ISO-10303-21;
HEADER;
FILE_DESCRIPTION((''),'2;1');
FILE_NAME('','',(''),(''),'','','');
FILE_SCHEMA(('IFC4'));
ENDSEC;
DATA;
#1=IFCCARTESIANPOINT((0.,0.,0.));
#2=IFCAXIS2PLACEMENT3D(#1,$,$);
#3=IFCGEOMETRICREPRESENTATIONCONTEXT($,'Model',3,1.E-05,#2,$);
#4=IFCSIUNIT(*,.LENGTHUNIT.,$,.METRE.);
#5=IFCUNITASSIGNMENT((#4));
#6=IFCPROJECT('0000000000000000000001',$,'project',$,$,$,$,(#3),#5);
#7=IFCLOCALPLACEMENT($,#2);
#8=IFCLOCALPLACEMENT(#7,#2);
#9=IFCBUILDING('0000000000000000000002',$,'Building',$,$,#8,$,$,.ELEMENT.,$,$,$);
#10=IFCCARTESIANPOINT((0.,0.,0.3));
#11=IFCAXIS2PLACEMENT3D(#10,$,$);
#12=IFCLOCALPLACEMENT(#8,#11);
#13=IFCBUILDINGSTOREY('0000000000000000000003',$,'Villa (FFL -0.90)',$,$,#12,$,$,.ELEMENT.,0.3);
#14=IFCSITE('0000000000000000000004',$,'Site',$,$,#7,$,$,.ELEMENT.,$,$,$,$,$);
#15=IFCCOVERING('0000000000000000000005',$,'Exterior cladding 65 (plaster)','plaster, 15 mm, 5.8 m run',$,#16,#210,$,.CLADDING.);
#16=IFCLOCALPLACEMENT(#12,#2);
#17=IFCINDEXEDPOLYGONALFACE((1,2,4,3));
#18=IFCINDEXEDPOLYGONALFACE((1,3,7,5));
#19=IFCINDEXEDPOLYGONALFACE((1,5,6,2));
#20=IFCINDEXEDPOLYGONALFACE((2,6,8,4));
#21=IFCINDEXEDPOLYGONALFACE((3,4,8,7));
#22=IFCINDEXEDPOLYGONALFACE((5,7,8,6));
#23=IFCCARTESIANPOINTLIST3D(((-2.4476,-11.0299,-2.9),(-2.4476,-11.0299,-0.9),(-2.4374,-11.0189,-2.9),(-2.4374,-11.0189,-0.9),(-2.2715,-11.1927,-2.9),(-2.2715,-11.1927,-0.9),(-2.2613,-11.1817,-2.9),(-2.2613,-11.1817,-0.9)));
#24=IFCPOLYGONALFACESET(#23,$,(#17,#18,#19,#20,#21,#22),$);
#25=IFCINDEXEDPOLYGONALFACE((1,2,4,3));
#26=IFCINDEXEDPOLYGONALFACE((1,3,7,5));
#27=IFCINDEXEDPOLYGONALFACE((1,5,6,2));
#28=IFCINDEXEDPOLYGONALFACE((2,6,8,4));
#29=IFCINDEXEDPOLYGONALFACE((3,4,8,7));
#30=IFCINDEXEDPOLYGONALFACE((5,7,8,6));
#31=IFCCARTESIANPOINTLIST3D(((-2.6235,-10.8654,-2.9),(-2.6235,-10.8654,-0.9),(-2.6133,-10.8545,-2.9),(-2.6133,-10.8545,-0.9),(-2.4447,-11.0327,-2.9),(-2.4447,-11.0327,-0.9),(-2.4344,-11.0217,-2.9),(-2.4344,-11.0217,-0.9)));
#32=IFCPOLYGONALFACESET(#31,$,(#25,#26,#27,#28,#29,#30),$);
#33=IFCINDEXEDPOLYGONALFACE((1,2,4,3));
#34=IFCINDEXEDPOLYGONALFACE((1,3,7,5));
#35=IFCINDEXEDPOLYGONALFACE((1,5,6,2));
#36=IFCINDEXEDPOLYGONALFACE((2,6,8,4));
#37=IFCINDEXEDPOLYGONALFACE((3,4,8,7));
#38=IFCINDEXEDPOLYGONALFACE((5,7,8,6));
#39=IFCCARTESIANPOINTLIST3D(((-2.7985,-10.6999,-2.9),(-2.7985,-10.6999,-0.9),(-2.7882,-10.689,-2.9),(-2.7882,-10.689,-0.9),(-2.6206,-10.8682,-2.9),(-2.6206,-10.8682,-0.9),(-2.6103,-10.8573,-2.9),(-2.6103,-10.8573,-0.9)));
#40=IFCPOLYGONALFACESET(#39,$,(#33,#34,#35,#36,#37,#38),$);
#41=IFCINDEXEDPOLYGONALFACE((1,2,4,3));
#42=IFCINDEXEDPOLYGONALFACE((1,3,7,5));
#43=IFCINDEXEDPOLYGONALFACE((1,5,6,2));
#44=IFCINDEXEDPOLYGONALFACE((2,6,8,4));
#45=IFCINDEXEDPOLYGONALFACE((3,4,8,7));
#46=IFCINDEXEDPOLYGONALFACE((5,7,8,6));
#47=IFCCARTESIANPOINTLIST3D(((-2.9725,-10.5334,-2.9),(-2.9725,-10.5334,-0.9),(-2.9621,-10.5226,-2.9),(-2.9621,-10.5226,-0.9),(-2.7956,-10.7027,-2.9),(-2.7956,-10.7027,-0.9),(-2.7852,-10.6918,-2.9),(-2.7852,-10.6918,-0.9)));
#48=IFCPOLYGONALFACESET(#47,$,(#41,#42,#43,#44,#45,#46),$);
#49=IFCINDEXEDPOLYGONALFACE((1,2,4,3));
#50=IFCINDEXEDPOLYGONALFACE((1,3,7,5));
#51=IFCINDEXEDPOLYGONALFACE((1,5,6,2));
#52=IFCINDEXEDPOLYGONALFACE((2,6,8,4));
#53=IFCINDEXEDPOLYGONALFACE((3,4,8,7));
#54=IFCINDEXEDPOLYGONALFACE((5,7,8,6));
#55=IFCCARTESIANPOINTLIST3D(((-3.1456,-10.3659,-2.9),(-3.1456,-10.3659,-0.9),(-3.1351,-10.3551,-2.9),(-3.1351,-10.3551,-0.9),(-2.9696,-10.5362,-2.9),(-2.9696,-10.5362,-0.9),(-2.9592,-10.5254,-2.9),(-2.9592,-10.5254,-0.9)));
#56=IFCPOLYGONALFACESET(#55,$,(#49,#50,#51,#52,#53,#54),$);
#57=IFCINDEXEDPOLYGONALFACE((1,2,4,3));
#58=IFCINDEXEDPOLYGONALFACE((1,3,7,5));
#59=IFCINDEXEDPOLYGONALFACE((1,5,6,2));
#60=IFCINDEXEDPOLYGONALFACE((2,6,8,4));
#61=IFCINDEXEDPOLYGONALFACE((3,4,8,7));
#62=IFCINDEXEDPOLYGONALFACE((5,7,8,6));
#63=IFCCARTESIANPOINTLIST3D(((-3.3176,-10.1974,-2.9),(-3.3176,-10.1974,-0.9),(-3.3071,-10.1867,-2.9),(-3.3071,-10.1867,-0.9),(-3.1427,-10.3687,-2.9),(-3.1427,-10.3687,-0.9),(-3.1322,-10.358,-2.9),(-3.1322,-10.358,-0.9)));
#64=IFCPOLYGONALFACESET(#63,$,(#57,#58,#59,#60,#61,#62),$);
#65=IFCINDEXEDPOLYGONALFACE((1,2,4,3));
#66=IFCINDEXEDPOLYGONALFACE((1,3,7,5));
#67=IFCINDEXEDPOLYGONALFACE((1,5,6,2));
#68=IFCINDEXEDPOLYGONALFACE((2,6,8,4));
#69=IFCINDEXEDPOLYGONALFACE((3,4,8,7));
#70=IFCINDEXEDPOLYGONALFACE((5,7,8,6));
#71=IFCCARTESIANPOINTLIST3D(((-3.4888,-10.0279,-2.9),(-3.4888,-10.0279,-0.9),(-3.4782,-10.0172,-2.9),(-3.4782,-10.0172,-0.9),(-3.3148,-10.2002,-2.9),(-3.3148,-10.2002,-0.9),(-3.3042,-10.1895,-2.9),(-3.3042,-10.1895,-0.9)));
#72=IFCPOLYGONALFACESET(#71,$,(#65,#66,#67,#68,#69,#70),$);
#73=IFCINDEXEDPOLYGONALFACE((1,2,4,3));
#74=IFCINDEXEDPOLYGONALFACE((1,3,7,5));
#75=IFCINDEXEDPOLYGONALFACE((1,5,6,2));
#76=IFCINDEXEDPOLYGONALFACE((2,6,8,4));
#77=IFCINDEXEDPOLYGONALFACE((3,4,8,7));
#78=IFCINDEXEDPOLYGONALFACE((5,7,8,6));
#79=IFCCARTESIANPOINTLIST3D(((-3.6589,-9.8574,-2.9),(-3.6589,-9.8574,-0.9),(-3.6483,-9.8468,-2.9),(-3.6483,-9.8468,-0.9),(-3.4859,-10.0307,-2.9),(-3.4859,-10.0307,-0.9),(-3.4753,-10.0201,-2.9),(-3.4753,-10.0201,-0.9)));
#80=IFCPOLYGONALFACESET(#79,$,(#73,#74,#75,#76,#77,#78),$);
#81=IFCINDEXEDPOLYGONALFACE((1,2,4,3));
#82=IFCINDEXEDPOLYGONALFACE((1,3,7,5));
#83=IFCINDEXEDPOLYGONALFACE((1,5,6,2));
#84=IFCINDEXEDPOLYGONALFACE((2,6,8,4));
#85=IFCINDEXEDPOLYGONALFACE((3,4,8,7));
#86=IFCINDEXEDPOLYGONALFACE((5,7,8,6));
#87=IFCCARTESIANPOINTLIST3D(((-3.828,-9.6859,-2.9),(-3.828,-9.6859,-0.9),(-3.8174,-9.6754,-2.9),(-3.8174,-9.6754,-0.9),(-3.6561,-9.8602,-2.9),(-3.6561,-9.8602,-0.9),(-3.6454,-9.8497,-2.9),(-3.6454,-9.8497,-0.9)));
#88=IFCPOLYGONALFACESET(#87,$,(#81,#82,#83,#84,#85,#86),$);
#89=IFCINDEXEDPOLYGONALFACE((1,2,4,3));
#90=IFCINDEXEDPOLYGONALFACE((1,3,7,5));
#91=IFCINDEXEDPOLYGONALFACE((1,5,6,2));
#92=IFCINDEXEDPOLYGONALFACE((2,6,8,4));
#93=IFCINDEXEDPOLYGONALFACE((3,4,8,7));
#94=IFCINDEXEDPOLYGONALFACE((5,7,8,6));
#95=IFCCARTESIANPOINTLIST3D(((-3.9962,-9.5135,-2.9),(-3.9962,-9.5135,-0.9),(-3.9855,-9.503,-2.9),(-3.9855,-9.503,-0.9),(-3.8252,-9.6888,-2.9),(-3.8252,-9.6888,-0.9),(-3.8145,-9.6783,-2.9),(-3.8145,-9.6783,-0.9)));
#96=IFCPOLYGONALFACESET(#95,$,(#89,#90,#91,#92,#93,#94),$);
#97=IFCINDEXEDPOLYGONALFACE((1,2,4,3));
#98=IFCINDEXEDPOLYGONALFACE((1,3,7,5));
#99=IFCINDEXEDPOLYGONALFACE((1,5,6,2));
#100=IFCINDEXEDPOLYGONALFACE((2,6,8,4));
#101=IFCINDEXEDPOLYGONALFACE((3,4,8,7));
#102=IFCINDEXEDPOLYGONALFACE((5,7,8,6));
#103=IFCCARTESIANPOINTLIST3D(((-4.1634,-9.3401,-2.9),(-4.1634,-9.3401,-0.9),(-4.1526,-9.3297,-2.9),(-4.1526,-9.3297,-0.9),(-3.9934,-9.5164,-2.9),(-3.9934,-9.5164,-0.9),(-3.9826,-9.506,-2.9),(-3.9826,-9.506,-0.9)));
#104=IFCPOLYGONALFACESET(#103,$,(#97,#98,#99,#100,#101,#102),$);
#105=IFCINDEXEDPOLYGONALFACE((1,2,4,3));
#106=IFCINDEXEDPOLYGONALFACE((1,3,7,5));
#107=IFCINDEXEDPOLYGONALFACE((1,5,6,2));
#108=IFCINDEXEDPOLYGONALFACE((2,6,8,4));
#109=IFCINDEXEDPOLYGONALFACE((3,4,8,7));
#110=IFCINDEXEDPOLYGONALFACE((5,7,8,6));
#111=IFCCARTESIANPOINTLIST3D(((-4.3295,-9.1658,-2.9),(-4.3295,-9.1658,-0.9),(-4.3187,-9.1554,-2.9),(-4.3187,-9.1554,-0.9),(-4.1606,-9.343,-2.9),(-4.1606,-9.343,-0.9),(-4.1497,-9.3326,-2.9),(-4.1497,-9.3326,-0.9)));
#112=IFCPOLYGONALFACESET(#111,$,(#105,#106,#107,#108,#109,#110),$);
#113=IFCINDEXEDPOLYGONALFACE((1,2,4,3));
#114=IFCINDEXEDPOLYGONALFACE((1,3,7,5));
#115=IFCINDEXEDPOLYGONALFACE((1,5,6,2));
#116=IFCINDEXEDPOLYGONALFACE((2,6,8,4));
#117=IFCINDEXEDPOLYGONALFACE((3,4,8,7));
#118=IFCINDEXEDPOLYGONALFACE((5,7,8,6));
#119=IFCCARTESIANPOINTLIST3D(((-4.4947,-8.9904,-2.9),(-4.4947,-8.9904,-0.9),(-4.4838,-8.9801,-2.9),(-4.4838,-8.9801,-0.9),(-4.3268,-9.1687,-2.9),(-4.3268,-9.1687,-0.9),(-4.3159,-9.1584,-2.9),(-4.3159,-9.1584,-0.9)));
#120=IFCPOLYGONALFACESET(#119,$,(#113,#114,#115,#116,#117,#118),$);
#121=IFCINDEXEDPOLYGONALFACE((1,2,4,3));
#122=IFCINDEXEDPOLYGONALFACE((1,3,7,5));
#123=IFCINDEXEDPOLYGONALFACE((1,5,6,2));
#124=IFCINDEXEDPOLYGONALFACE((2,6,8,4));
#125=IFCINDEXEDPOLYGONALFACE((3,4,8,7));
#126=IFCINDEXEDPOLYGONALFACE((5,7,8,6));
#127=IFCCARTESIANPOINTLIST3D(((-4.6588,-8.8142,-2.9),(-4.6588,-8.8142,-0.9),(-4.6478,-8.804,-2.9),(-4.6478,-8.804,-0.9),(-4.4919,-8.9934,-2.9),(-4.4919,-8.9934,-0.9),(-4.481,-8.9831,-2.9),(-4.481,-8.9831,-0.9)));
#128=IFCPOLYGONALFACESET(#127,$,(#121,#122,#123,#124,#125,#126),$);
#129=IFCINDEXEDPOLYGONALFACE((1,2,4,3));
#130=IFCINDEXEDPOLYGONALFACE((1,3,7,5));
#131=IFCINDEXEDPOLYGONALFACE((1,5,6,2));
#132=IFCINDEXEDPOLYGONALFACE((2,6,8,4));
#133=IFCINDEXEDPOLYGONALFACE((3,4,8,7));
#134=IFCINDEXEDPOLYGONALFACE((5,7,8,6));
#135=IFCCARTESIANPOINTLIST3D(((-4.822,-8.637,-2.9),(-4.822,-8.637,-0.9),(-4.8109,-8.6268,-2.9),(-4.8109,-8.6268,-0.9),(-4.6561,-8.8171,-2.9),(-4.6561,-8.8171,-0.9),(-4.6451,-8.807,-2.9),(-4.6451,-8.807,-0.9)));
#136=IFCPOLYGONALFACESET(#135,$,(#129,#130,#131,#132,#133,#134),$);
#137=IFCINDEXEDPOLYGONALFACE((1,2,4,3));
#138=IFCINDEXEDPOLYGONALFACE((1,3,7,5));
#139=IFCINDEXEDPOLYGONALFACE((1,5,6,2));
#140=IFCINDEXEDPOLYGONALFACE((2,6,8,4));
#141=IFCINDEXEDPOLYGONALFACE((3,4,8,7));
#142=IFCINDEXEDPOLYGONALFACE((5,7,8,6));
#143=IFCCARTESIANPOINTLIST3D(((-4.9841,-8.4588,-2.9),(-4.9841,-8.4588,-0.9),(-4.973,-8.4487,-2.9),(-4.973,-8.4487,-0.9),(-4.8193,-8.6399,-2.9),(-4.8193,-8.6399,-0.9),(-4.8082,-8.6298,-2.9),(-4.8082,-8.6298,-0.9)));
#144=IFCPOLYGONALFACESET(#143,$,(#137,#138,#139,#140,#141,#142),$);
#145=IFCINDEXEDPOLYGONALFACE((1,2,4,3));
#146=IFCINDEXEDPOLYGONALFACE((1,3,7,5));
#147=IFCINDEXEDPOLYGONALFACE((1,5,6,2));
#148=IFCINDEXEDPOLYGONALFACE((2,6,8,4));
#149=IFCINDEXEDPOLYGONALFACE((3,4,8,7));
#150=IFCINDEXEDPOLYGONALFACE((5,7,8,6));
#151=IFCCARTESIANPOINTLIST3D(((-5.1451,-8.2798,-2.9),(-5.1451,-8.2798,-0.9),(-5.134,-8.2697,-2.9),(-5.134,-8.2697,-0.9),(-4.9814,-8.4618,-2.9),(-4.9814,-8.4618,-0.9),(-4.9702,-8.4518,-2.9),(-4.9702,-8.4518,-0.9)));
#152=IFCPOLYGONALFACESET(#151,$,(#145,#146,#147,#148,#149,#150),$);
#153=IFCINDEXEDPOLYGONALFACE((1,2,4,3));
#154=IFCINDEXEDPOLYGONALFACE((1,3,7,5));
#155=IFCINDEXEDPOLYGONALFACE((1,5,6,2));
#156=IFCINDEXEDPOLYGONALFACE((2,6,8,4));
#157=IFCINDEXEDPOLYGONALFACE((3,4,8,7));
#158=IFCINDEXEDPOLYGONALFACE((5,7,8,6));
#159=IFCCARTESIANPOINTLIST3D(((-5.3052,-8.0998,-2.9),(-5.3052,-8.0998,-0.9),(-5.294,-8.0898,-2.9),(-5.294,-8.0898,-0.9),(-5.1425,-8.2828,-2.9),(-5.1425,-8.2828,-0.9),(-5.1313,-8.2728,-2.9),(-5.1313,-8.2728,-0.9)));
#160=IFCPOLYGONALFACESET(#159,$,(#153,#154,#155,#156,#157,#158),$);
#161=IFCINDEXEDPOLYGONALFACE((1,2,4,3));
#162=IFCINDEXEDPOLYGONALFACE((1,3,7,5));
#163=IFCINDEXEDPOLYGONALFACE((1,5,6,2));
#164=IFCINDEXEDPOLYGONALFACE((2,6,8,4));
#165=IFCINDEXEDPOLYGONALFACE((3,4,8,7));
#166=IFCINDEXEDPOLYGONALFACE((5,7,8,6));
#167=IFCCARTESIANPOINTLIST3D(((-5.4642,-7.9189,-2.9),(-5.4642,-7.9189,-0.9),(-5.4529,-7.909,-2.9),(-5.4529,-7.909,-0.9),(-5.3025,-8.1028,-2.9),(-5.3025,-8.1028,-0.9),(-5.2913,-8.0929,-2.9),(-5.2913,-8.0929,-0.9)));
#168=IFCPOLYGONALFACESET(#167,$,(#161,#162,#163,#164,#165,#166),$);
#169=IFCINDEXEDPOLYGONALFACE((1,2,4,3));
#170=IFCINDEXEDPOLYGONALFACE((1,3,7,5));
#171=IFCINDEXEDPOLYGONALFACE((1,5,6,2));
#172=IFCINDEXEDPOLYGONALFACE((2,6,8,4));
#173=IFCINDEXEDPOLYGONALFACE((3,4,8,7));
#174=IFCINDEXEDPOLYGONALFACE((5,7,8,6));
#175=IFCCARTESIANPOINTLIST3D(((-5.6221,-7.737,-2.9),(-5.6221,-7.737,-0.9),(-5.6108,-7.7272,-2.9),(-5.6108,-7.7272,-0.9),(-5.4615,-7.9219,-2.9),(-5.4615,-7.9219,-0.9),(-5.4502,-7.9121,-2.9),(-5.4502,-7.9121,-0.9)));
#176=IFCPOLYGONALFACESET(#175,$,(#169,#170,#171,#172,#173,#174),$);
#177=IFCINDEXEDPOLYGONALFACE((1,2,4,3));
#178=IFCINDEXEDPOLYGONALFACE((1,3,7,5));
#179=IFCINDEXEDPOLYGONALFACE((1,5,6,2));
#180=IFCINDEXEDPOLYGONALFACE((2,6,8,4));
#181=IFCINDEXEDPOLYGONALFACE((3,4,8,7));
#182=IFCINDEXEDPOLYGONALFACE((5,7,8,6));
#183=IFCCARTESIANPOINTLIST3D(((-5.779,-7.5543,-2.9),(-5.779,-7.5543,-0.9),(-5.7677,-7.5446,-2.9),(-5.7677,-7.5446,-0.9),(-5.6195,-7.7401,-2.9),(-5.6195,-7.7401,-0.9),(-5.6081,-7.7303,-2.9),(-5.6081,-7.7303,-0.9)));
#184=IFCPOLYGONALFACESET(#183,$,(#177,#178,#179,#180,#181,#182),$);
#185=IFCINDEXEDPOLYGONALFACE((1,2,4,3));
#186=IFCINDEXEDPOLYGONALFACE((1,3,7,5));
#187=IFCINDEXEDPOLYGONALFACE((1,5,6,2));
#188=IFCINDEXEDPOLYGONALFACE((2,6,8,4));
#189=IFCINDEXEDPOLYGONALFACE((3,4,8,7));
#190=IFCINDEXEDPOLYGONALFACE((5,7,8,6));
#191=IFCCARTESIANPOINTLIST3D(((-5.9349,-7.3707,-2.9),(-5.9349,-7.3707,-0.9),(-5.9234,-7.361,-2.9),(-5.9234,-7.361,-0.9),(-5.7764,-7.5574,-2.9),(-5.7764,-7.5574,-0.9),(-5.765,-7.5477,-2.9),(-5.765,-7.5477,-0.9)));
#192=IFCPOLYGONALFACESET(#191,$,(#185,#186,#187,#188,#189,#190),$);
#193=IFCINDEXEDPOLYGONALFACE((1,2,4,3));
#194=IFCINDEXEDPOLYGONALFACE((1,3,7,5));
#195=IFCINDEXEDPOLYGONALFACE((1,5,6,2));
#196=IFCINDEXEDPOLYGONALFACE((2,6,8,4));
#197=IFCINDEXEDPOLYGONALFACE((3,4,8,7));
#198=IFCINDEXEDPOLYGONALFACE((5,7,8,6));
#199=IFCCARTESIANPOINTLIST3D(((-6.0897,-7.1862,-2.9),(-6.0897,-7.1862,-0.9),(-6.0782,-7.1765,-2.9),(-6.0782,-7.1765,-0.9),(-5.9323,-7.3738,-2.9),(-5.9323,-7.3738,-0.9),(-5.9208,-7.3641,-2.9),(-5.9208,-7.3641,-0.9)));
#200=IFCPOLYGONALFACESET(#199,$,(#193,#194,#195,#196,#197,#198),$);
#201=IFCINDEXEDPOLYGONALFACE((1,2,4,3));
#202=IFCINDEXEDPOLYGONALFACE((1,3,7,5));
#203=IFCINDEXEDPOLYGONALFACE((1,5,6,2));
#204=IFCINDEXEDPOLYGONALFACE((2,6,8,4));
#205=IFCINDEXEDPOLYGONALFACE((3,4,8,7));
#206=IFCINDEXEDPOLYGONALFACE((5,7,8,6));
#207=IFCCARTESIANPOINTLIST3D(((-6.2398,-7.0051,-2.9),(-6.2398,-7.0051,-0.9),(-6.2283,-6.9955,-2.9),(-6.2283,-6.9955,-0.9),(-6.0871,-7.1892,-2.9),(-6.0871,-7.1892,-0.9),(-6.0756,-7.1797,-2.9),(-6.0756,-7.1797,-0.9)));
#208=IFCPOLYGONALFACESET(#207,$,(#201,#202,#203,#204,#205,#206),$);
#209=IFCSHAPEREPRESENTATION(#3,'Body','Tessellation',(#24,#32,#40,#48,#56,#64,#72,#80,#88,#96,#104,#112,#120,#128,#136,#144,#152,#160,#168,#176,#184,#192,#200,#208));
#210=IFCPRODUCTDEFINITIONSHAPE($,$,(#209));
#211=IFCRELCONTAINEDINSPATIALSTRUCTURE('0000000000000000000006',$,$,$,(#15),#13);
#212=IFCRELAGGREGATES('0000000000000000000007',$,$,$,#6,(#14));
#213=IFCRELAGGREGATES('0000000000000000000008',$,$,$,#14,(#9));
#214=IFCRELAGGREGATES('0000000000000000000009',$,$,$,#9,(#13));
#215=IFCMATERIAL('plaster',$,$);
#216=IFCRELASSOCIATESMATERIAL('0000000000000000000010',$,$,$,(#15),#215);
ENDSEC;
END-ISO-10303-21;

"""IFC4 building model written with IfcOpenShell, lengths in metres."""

from ifc_helpers import new_model, si_unit, frame, origin, origin_with_axes, place, context, project, spatial, polyline, outline, extrude, material, element, save


model = new_model("IFC4")

# Units and contexts
model_context = context("Model", 3, precision=1e-05, world=origin())
ifc_project = project(units=[si_unit("LENGTHUNIT", "METRE")], contexts=[model_context])

# Site, building, storey
site_placement = place(None, origin())
site = spatial("IfcSite", under=ifc_project, at=site_placement, Name="Site", CompositionType="ELEMENT")
building_placement = place(site_placement, origin())
building = spatial("IfcBuilding", under=site, at=building_placement, Name="Building", CompositionType="ELEMENT")
storey_placement = place(building_placement, frame((0.0, 0.0, 0.3)))
storey = spatial("IfcBuildingStorey", under=building, at=storey_placement, Name="Villa (FFL -0.90)", CompositionType="ELEMENT", Elevation=0.3)

# Covering
ifc_material = material(Name="plaster")
covering_1_placement = place(storey_placement, origin_with_axes())
element("IfcCovering", 1, at=covering_1_placement, inside=storey, material=ifc_material, Name="Exterior cladding 65 (plaster)", Description="plaster, 15 mm, 5.8 m run", PredefinedType="CLADDING", context=model_context, shape_type="SweptSolid", body=[
    extrude(outline(polyline([(-2.2613, -11.1817), (-2.4374, -11.0189), (-2.4476, -11.0299), (-2.2715, -11.1927), (-2.2613, -11.1817)])), frame((0.0, 0.0, -2.9)), (0.0, 0.0, 1.0), 2.0),
    extrude(outline(polyline([(-2.4344, -11.0217), (-2.6133, -10.8545), (-2.6235, -10.8654), (-2.4447, -11.0327), (-2.4344, -11.0217)])), frame((0.0, 0.0, -2.9)), (0.0, 0.0, 1.0), 2.0),
    extrude(outline(polyline([(-2.6103, -10.8573), (-2.7882, -10.689), (-2.7985, -10.6999), (-2.6206, -10.8682), (-2.6103, -10.8573)])), frame((0.0, 0.0, -2.9)), (0.0, 0.0, 1.0), 2.0),
    extrude(outline(polyline([(-2.7852, -10.6918), (-2.9621, -10.5226), (-2.9725, -10.5334), (-2.7956, -10.7027), (-2.7852, -10.6918)])), frame((0.0, 0.0, -2.9)), (0.0, 0.0, 1.0), 2.0),
    extrude(outline(polyline([(-2.9592, -10.5254), (-3.1351, -10.3551), (-3.1456, -10.3659), (-2.9696, -10.5362), (-2.9592, -10.5254)])), frame((0.0, 0.0, -2.9)), (0.0, 0.0, 1.0), 2.0),
    extrude(outline(polyline([(-3.1322, -10.358), (-3.3071, -10.1867), (-3.3176, -10.1974), (-3.1427, -10.3687), (-3.1322, -10.358)])), frame((0.0, 0.0, -2.9)), (0.0, 0.0, 1.0), 2.0),
    extrude(outline(polyline([(-3.3042, -10.1895), (-3.4782, -10.0172), (-3.4888, -10.0279), (-3.3148, -10.2002), (-3.3042, -10.1895)])), frame((0.0, 0.0, -2.9)), (0.0, 0.0, 1.0), 2.0),
    extrude(outline(polyline([(-3.4753, -10.0201), (-3.6483, -9.8468), (-3.6589, -9.8574), (-3.4859, -10.0307), (-3.4753, -10.0201)])), frame((0.0, 0.0, -2.9)), (0.0, 0.0, 1.0), 2.0),
    extrude(outline(polyline([(-3.6454, -9.8497), (-3.8174, -9.6754), (-3.828, -9.6859), (-3.6561, -9.8602), (-3.6454, -9.8497)])), frame((0.0, 0.0, -2.9)), (0.0, 0.0, 1.0), 2.0),
    extrude(outline(polyline([(-3.8145, -9.6783), (-3.9855, -9.503), (-3.9962, -9.5135), (-3.8252, -9.6888), (-3.8145, -9.6783)])), frame((0.0, 0.0, -2.9)), (0.0, 0.0, 1.0), 2.0),
    extrude(outline(polyline([(-3.9826, -9.506), (-4.1526, -9.3297), (-4.1634, -9.3401), (-3.9934, -9.5164), (-3.9826, -9.506)])), frame((0.0, 0.0, -2.9)), (0.0, 0.0, 1.0), 2.0),
    extrude(outline(polyline([(-4.1497, -9.3326), (-4.3187, -9.1554), (-4.3295, -9.1658), (-4.1606, -9.343), (-4.1497, -9.3326)])), frame((0.0, 0.0, -2.9)), (0.0, 0.0, 1.0), 2.0),
    extrude(outline(polyline([(-4.3159, -9.1584), (-4.4838, -8.9801), (-4.4947, -8.9904), (-4.3268, -9.1687), (-4.3159, -9.1584)])), frame((0.0, 0.0, -2.9)), (0.0, 0.0, 1.0), 2.0),
    extrude(outline(polyline([(-4.481, -8.9831), (-4.6478, -8.804), (-4.6588, -8.8142), (-4.4919, -8.9934), (-4.481, -8.9831)])), frame((0.0, 0.0, -2.9)), (0.0, 0.0, 1.0), 2.0),
    extrude(outline(polyline([(-4.6451, -8.807), (-4.8109, -8.6268), (-4.822, -8.637), (-4.6561, -8.8171), (-4.6451, -8.807)])), frame((0.0, 0.0, -2.9)), (0.0, 0.0, 1.0), 2.0),
    extrude(outline(polyline([(-4.8082, -8.6298), (-4.973, -8.4487), (-4.9841, -8.4588), (-4.8193, -8.6399), (-4.8082, -8.6298)])), frame((0.0, 0.0, -2.9)), (0.0, 0.0, 1.0), 2.0),
    extrude(outline(polyline([(-4.9702, -8.4518), (-5.134, -8.2697), (-5.1451, -8.2798), (-4.9814, -8.4618), (-4.9702, -8.4518)])), frame((0.0, 0.0, -2.9)), (0.0, 0.0, 1.0), 2.0),
    extrude(outline(polyline([(-5.1313, -8.2728), (-5.294, -8.0898), (-5.3052, -8.0998), (-5.1425, -8.2828), (-5.1313, -8.2728)])), frame((0.0, 0.0, -2.9)), (0.0, 0.0, 1.0), 2.0),
    extrude(outline(polyline([(-5.2913, -8.0929), (-5.4529, -7.909), (-5.4642, -7.9189), (-5.3025, -8.1028), (-5.2913, -8.0929)])), frame((0.0, 0.0, -2.9)), (0.0, 0.0, 1.0), 2.0),
    extrude(outline(polyline([(-5.4502, -7.9121), (-5.6108, -7.7272), (-5.6221, -7.737), (-5.4615, -7.9219), (-5.4502, -7.9121)])), frame((0.0, 0.0, -2.9)), (0.0, 0.0, 1.0), 2.0),
    extrude(outline(polyline([(-5.6081, -7.7303), (-5.7677, -7.5446), (-5.779, -7.5543), (-5.6195, -7.7401), (-5.6081, -7.7303)])), frame((0.0, 0.0, -2.9)), (0.0, 0.0, 1.0), 2.0),
    extrude(outline(polyline([(-5.765, -7.5477), (-5.9234, -7.361), (-5.9349, -7.3707), (-5.7764, -7.5574), (-5.765, -7.5477)])), frame((0.0, 0.0, -2.9)), (0.0, 0.0, 1.0), 2.0),
    extrude(outline(polyline([(-5.9208, -7.3641), (-6.0782, -7.1765), (-6.0897, -7.1862), (-5.9323, -7.3738), (-5.9208, -7.3641)])), frame((0.0, 0.0, -2.9)), (0.0, 0.0, 1.0), 2.0),
    extrude(outline(polyline([(-6.0756, -7.1797), (-6.2283, -6.9955), (-6.2398, -7.0051), (-6.0871, -7.1892), (-6.0756, -7.1797)])), frame((0.0, 0.0, -2.9)), (0.0, 0.0, 1.0), 2.0),
])

save(model, "model.ifc")
